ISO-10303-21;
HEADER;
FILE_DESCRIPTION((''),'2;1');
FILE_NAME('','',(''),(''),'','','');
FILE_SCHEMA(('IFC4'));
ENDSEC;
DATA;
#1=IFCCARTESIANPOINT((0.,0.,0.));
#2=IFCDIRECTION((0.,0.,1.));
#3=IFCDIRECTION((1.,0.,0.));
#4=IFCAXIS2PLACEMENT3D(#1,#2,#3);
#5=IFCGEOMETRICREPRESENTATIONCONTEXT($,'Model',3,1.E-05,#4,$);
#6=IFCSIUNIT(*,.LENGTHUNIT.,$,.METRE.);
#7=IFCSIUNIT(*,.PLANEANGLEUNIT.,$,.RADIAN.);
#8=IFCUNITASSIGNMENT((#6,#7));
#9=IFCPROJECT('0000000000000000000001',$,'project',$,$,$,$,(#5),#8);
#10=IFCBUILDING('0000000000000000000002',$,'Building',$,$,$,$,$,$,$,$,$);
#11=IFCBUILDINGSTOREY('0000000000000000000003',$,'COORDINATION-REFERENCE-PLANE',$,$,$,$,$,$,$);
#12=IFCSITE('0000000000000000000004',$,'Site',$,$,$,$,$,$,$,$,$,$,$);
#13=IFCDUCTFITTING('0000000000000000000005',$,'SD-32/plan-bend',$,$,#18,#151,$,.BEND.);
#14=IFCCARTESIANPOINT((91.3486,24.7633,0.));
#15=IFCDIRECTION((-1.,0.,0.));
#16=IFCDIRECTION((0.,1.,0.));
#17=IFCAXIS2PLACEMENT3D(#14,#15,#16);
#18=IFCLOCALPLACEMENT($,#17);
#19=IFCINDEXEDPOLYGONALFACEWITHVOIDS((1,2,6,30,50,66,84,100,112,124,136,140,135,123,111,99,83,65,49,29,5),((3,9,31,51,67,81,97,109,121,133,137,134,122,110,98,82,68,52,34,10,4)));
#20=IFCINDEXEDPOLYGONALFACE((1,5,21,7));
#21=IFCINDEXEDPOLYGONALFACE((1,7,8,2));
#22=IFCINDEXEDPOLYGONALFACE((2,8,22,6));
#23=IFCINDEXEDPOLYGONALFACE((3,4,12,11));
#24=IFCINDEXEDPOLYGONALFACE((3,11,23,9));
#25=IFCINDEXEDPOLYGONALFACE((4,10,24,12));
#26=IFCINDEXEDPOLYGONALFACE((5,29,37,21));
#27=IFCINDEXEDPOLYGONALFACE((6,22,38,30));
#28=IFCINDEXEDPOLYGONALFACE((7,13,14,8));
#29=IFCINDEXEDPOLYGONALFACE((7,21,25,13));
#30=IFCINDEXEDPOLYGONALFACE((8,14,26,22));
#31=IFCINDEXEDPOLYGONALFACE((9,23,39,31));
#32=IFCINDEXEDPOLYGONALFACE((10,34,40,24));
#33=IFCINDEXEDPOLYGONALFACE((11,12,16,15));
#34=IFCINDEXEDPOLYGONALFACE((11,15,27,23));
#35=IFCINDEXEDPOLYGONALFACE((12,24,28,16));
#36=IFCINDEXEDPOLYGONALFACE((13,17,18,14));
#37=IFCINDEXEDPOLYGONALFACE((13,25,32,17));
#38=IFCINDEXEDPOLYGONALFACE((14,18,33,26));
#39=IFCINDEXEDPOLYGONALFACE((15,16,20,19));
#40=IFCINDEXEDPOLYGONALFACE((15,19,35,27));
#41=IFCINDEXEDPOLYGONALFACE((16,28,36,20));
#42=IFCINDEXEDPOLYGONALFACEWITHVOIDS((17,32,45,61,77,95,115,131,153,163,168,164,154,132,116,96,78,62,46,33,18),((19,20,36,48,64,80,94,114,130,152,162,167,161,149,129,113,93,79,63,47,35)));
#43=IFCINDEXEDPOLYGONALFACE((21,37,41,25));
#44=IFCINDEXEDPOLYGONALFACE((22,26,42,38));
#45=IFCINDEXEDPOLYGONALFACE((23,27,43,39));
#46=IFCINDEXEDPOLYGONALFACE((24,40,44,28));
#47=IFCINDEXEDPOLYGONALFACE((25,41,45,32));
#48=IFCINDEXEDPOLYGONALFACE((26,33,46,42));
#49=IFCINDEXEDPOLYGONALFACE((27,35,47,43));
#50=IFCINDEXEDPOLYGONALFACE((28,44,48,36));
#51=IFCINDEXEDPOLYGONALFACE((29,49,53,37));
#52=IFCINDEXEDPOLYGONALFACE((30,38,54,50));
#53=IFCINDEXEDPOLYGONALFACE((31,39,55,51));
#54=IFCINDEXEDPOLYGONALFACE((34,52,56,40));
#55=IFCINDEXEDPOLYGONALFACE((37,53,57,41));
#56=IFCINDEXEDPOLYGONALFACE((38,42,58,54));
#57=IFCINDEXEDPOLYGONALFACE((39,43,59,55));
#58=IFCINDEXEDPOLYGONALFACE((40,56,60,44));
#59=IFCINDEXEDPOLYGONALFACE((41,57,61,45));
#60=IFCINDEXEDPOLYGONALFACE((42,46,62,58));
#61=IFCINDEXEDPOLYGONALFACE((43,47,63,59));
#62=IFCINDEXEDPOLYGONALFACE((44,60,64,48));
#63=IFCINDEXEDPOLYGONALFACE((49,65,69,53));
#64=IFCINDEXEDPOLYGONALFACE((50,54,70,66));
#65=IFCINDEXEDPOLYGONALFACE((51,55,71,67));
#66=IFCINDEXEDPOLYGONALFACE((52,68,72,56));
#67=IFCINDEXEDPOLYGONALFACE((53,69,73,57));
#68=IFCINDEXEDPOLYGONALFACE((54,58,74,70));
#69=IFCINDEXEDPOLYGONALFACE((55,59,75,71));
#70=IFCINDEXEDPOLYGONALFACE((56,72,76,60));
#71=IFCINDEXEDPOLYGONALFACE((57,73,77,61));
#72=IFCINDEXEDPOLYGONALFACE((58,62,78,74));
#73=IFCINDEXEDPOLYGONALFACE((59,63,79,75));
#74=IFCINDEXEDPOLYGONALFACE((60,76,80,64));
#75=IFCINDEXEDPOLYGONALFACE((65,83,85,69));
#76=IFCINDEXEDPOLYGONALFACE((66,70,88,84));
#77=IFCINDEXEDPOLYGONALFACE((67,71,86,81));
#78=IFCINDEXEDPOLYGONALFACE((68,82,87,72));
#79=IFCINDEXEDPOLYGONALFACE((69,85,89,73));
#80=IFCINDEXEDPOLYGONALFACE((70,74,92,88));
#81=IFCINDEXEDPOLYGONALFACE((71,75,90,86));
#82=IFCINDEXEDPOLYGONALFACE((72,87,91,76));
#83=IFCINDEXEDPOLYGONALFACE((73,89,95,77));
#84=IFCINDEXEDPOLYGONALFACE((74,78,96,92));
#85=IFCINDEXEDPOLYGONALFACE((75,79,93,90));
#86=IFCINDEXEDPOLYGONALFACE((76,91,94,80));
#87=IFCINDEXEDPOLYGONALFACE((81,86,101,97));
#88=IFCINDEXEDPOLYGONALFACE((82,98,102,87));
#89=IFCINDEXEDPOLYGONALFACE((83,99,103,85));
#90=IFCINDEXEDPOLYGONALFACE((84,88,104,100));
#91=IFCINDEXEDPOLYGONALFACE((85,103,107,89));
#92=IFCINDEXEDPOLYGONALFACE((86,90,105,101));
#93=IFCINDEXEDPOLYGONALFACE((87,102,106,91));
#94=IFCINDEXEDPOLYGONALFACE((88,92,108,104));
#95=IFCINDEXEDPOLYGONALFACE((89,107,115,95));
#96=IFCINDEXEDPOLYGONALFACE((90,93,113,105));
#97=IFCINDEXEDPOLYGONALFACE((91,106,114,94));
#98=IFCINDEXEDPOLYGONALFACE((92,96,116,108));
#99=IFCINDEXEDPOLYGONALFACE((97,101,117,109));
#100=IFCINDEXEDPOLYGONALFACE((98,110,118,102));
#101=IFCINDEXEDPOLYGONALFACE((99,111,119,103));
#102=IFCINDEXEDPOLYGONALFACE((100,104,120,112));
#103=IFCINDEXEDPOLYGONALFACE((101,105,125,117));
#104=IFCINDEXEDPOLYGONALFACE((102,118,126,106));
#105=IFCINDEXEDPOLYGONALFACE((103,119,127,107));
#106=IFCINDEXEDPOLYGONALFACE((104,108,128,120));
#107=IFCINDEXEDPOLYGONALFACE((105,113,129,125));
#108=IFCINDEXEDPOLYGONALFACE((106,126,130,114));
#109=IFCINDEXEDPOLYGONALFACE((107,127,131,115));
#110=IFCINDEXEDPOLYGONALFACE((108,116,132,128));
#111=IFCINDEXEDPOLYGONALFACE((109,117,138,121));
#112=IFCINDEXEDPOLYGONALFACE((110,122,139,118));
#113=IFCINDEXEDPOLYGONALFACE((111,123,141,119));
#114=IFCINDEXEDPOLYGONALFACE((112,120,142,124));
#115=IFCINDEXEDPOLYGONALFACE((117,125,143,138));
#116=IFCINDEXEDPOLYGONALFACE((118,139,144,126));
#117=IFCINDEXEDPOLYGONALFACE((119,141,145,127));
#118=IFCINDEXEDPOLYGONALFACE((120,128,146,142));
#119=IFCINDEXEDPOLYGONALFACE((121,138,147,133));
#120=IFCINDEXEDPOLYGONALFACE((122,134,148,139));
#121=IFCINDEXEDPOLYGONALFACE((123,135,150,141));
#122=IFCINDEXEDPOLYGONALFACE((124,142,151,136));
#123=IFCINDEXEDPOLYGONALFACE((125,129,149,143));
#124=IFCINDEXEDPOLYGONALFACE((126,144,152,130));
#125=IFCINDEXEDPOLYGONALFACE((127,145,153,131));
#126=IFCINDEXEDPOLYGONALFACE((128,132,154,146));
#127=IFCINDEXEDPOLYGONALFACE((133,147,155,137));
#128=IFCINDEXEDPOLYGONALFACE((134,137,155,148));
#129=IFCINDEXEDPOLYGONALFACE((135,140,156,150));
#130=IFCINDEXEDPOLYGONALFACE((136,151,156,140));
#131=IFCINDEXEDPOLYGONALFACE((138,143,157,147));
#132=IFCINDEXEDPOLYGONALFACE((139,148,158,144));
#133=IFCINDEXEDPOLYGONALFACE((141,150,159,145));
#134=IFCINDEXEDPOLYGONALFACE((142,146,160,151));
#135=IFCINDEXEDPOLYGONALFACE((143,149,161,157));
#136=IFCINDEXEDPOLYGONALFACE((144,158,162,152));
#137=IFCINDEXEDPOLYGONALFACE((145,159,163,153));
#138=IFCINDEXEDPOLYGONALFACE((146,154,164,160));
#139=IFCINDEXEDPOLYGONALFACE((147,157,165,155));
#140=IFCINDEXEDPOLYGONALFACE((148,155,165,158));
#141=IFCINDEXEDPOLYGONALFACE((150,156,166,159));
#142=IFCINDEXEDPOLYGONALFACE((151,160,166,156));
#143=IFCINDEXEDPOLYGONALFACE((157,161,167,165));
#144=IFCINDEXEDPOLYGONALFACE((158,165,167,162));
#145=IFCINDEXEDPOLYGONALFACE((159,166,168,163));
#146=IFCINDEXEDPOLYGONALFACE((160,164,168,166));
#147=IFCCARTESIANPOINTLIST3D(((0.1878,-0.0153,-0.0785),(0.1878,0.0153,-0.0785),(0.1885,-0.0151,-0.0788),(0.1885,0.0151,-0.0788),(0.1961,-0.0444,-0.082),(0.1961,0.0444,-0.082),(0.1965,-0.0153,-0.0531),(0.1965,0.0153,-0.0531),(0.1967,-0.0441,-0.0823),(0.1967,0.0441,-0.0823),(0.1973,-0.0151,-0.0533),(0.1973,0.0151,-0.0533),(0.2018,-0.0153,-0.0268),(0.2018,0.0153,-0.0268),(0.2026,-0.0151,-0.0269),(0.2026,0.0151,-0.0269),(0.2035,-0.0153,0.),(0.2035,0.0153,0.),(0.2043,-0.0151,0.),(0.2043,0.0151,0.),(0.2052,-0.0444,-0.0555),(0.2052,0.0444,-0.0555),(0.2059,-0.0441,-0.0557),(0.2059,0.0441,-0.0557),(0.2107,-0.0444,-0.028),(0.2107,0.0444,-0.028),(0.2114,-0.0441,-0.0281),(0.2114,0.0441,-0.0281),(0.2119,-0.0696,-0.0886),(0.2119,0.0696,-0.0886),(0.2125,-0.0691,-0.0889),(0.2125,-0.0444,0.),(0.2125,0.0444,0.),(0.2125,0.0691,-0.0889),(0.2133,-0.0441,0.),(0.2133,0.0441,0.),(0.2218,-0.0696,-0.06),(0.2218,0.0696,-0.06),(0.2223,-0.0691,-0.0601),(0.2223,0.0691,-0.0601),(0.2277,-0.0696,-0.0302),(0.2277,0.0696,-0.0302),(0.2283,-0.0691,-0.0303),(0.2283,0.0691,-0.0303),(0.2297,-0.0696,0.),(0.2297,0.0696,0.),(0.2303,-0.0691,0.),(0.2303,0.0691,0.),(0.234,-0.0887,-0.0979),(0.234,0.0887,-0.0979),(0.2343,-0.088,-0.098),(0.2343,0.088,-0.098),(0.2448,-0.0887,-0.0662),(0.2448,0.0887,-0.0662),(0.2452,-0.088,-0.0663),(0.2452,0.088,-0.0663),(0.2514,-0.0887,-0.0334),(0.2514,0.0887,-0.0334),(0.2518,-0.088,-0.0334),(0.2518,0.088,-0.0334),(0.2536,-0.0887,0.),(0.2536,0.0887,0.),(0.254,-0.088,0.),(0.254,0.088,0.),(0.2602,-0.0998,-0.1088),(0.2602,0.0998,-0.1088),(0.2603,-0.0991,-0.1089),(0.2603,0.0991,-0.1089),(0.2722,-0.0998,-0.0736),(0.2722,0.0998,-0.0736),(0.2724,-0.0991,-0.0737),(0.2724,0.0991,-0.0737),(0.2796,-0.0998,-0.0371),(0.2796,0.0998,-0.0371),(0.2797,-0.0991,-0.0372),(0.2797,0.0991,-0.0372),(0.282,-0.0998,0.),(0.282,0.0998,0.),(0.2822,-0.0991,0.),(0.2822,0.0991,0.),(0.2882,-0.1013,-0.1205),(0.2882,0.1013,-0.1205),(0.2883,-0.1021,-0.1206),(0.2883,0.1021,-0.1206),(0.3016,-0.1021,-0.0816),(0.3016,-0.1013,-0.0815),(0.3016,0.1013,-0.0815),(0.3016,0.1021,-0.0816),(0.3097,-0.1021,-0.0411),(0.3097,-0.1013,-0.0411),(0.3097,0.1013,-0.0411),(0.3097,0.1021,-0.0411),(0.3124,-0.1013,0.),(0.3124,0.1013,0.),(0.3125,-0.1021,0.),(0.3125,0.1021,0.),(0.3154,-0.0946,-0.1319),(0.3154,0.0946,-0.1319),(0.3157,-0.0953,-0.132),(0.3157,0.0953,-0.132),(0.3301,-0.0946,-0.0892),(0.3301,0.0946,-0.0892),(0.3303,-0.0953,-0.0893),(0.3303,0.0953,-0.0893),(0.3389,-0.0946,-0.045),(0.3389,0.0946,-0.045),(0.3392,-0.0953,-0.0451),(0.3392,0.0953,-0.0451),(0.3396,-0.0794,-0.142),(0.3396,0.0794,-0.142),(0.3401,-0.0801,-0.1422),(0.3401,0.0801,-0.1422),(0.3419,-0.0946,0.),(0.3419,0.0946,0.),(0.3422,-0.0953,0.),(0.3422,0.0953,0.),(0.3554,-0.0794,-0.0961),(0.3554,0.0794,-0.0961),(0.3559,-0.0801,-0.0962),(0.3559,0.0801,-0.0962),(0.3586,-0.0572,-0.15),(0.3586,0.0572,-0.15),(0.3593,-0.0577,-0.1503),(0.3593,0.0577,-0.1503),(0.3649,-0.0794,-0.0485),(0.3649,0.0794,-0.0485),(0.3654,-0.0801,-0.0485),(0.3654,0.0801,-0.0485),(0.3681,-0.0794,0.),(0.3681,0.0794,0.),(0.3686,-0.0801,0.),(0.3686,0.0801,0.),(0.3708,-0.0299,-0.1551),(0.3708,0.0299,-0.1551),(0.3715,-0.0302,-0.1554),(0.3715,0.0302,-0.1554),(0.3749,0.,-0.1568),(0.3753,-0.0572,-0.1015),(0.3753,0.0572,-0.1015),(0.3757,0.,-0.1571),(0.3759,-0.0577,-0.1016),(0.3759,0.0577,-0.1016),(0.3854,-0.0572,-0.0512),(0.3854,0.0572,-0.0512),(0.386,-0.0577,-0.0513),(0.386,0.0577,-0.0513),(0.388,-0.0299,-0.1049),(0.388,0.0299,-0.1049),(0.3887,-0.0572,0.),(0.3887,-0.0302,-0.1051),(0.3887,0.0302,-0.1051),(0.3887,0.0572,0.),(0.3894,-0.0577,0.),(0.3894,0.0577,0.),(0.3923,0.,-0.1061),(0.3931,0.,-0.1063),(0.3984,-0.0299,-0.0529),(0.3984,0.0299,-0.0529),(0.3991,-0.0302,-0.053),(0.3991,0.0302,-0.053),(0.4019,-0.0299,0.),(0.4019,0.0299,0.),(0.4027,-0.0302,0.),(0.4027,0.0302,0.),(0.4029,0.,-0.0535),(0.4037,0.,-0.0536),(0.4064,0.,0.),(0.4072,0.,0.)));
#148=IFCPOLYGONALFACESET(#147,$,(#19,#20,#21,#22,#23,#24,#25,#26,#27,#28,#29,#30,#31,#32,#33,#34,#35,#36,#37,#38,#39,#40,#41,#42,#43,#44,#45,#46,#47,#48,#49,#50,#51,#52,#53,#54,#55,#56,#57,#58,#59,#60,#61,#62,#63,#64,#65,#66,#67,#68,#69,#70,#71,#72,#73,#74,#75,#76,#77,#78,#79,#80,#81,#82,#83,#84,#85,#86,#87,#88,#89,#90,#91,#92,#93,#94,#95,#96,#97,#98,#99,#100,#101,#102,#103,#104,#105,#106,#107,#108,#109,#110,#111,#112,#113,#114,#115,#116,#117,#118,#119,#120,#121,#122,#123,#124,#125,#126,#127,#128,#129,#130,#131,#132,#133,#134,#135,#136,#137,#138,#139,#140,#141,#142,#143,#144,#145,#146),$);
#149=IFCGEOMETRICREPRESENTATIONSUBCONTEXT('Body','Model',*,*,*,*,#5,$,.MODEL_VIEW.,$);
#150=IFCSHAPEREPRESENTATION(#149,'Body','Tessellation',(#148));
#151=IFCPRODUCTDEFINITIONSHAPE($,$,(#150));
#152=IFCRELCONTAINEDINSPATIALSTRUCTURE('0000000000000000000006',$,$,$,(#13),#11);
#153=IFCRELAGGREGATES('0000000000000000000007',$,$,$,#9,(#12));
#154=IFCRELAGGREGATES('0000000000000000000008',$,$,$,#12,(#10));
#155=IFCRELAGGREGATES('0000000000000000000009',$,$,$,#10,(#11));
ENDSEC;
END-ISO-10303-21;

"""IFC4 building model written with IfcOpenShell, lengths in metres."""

from ifc_helpers import new_model, entity, si_unit, frame, origin_with_axes, place, context, subcontext, project, spatial, element, save


model = new_model("IFC4")

# Units and contexts
model_context_1 = context("Model", 3, precision=1e-05, world=origin_with_axes())
body_context_1 = subcontext(model_context_1, "Body", "Model", "MODEL_VIEW")
ifc_project = project(units=[si_unit("LENGTHUNIT", "METRE"), si_unit("PLANEANGLEUNIT", "RADIAN")], contexts=[model_context_1])

# Site, building, storey
site = spatial("IfcSite", under=ifc_project, Name="Site")
building = spatial("IfcBuilding", under=site, Name="Building")
storey = spatial("IfcBuildingStorey", under=building, Name="COORDINATION-REFERENCE-PLANE")

# Duct fitting
duct_fitting_1_placement = place(None, frame((91.3486, 24.7633, 0.0), z_axis=(-1.0, 0.0, 0.0), x_axis=(0.0, 1.0, 0.0)))
element("IfcDuctFitting", 1, at=duct_fitting_1_placement, inside=storey, Name="SD-32/plan-bend", PredefinedType="BEND", context=body_context_1, shape_type="SweptSolid", body=[
    entity("IfcRevolvedAreaSolid", entity("IfcCircleHollowProfileDef", "AREA", None, entity("IfcAxis2Placement2D", entity("IfcCartesianPoint", [0.3048, 0.0])), 0.1024, 0.0008), entity("IfcAxis2Placement3D", entity("IfcCartesianPoint", [0.0, 0.0, 0.0]), entity("IfcDirection", [0.0, 0.0, 1.0]), entity("IfcDirection", [1.0, 0.0, 0.0])), entity("IfcAxis1Placement", entity("IfcCartesianPoint", [0.0, 0.0, 0.0]), entity("IfcDirection", [0.0, 1.0, 0.0])), 0.396124),
])

save(model, "model.ifc")
